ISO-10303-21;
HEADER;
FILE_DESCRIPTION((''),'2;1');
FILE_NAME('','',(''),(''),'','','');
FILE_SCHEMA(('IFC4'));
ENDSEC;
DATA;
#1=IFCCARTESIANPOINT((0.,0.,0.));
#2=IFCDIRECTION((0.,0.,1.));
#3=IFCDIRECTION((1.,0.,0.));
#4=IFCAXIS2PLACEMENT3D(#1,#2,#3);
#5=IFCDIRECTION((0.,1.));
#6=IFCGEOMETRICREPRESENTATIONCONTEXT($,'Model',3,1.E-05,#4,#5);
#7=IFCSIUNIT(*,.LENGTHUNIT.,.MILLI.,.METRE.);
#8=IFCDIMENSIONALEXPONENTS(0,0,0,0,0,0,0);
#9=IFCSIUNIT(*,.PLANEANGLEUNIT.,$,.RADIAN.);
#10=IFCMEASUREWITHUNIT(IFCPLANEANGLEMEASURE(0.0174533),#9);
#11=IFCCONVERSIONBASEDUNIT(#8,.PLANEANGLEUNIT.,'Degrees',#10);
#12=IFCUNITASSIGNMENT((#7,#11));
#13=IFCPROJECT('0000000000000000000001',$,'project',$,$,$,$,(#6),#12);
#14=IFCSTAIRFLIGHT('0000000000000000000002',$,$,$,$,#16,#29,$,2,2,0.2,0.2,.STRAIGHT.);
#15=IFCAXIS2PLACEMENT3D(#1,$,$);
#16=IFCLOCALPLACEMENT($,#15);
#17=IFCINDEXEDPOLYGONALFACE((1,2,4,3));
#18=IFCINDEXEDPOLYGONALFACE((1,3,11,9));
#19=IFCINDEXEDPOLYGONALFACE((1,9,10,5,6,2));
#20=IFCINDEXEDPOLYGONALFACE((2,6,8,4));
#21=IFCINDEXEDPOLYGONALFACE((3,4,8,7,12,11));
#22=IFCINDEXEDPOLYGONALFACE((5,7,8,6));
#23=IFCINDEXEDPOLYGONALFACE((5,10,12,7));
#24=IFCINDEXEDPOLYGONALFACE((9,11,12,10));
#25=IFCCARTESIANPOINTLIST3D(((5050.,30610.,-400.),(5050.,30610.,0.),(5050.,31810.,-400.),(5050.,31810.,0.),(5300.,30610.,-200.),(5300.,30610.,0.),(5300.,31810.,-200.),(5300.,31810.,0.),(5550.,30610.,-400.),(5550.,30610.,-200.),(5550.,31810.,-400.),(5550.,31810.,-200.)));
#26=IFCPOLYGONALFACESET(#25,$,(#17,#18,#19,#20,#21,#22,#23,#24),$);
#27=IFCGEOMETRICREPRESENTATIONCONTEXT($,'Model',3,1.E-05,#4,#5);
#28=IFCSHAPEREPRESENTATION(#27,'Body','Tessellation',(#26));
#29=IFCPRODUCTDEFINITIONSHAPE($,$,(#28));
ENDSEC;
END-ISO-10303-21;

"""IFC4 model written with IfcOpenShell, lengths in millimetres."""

from ifc_helpers import new_model, entity, si_unit, converted_unit, direction, frame, origin_with_axes, place, context, project, polyline, outline, extrude, element, save


model = new_model("IFC4")

# Units and contexts
model_context_1 = context("Model", 3, precision=1e-05, world=origin_with_axes(), true_north=direction((0.0, 1.0)))
model_context_2 = context("Model", 3, precision=1e-05, world=origin_with_axes(), true_north=direction((0.0, 1.0)))
ifc_project = project(units=[si_unit("LENGTHUNIT", "METRE", prefix="MILLI"), converted_unit("PLANEANGLEUNIT", "Degrees", entity("IfcPlaneAngleMeasure", 0.0174533), si_unit("PLANEANGLEUNIT", "RADIAN"), dimensions=[0, 0, 0, 0, 0, 0, 0])], contexts=[model_context_1])

# Shared definitions
placement_1 = place(None, frame((0.0, 29610.0, 0.0)))

# Stair flight
stair_flight_1_placement = place(placement_1, frame((5050.0, 1000.0, 0.0), z_axis=(0.0, 1.0, 0.0), x_axis=(1.0, 0.0, 0.0)))
element("IfcStairFlight", 1, at=stair_flight_1_placement, NumberOfRisers=2, NumberOfTreads=2, PredefinedType="STRAIGHT", RiserHeight=0.2, TreadLength=0.2, context=model_context_2, shape_type="SweptSolid", body=[
    extrude(outline(polyline([(0.0, 0.0), (250.0, 0.0), (250.0, 200.0), (500.0, 200.0), (500.0, 400.0), (0.0, 400.0), (0.0, 0.0)])), origin_with_axes(), (0.0, 0.0, 1.0), 1200.0),
])

save(model, "model.ifc")
